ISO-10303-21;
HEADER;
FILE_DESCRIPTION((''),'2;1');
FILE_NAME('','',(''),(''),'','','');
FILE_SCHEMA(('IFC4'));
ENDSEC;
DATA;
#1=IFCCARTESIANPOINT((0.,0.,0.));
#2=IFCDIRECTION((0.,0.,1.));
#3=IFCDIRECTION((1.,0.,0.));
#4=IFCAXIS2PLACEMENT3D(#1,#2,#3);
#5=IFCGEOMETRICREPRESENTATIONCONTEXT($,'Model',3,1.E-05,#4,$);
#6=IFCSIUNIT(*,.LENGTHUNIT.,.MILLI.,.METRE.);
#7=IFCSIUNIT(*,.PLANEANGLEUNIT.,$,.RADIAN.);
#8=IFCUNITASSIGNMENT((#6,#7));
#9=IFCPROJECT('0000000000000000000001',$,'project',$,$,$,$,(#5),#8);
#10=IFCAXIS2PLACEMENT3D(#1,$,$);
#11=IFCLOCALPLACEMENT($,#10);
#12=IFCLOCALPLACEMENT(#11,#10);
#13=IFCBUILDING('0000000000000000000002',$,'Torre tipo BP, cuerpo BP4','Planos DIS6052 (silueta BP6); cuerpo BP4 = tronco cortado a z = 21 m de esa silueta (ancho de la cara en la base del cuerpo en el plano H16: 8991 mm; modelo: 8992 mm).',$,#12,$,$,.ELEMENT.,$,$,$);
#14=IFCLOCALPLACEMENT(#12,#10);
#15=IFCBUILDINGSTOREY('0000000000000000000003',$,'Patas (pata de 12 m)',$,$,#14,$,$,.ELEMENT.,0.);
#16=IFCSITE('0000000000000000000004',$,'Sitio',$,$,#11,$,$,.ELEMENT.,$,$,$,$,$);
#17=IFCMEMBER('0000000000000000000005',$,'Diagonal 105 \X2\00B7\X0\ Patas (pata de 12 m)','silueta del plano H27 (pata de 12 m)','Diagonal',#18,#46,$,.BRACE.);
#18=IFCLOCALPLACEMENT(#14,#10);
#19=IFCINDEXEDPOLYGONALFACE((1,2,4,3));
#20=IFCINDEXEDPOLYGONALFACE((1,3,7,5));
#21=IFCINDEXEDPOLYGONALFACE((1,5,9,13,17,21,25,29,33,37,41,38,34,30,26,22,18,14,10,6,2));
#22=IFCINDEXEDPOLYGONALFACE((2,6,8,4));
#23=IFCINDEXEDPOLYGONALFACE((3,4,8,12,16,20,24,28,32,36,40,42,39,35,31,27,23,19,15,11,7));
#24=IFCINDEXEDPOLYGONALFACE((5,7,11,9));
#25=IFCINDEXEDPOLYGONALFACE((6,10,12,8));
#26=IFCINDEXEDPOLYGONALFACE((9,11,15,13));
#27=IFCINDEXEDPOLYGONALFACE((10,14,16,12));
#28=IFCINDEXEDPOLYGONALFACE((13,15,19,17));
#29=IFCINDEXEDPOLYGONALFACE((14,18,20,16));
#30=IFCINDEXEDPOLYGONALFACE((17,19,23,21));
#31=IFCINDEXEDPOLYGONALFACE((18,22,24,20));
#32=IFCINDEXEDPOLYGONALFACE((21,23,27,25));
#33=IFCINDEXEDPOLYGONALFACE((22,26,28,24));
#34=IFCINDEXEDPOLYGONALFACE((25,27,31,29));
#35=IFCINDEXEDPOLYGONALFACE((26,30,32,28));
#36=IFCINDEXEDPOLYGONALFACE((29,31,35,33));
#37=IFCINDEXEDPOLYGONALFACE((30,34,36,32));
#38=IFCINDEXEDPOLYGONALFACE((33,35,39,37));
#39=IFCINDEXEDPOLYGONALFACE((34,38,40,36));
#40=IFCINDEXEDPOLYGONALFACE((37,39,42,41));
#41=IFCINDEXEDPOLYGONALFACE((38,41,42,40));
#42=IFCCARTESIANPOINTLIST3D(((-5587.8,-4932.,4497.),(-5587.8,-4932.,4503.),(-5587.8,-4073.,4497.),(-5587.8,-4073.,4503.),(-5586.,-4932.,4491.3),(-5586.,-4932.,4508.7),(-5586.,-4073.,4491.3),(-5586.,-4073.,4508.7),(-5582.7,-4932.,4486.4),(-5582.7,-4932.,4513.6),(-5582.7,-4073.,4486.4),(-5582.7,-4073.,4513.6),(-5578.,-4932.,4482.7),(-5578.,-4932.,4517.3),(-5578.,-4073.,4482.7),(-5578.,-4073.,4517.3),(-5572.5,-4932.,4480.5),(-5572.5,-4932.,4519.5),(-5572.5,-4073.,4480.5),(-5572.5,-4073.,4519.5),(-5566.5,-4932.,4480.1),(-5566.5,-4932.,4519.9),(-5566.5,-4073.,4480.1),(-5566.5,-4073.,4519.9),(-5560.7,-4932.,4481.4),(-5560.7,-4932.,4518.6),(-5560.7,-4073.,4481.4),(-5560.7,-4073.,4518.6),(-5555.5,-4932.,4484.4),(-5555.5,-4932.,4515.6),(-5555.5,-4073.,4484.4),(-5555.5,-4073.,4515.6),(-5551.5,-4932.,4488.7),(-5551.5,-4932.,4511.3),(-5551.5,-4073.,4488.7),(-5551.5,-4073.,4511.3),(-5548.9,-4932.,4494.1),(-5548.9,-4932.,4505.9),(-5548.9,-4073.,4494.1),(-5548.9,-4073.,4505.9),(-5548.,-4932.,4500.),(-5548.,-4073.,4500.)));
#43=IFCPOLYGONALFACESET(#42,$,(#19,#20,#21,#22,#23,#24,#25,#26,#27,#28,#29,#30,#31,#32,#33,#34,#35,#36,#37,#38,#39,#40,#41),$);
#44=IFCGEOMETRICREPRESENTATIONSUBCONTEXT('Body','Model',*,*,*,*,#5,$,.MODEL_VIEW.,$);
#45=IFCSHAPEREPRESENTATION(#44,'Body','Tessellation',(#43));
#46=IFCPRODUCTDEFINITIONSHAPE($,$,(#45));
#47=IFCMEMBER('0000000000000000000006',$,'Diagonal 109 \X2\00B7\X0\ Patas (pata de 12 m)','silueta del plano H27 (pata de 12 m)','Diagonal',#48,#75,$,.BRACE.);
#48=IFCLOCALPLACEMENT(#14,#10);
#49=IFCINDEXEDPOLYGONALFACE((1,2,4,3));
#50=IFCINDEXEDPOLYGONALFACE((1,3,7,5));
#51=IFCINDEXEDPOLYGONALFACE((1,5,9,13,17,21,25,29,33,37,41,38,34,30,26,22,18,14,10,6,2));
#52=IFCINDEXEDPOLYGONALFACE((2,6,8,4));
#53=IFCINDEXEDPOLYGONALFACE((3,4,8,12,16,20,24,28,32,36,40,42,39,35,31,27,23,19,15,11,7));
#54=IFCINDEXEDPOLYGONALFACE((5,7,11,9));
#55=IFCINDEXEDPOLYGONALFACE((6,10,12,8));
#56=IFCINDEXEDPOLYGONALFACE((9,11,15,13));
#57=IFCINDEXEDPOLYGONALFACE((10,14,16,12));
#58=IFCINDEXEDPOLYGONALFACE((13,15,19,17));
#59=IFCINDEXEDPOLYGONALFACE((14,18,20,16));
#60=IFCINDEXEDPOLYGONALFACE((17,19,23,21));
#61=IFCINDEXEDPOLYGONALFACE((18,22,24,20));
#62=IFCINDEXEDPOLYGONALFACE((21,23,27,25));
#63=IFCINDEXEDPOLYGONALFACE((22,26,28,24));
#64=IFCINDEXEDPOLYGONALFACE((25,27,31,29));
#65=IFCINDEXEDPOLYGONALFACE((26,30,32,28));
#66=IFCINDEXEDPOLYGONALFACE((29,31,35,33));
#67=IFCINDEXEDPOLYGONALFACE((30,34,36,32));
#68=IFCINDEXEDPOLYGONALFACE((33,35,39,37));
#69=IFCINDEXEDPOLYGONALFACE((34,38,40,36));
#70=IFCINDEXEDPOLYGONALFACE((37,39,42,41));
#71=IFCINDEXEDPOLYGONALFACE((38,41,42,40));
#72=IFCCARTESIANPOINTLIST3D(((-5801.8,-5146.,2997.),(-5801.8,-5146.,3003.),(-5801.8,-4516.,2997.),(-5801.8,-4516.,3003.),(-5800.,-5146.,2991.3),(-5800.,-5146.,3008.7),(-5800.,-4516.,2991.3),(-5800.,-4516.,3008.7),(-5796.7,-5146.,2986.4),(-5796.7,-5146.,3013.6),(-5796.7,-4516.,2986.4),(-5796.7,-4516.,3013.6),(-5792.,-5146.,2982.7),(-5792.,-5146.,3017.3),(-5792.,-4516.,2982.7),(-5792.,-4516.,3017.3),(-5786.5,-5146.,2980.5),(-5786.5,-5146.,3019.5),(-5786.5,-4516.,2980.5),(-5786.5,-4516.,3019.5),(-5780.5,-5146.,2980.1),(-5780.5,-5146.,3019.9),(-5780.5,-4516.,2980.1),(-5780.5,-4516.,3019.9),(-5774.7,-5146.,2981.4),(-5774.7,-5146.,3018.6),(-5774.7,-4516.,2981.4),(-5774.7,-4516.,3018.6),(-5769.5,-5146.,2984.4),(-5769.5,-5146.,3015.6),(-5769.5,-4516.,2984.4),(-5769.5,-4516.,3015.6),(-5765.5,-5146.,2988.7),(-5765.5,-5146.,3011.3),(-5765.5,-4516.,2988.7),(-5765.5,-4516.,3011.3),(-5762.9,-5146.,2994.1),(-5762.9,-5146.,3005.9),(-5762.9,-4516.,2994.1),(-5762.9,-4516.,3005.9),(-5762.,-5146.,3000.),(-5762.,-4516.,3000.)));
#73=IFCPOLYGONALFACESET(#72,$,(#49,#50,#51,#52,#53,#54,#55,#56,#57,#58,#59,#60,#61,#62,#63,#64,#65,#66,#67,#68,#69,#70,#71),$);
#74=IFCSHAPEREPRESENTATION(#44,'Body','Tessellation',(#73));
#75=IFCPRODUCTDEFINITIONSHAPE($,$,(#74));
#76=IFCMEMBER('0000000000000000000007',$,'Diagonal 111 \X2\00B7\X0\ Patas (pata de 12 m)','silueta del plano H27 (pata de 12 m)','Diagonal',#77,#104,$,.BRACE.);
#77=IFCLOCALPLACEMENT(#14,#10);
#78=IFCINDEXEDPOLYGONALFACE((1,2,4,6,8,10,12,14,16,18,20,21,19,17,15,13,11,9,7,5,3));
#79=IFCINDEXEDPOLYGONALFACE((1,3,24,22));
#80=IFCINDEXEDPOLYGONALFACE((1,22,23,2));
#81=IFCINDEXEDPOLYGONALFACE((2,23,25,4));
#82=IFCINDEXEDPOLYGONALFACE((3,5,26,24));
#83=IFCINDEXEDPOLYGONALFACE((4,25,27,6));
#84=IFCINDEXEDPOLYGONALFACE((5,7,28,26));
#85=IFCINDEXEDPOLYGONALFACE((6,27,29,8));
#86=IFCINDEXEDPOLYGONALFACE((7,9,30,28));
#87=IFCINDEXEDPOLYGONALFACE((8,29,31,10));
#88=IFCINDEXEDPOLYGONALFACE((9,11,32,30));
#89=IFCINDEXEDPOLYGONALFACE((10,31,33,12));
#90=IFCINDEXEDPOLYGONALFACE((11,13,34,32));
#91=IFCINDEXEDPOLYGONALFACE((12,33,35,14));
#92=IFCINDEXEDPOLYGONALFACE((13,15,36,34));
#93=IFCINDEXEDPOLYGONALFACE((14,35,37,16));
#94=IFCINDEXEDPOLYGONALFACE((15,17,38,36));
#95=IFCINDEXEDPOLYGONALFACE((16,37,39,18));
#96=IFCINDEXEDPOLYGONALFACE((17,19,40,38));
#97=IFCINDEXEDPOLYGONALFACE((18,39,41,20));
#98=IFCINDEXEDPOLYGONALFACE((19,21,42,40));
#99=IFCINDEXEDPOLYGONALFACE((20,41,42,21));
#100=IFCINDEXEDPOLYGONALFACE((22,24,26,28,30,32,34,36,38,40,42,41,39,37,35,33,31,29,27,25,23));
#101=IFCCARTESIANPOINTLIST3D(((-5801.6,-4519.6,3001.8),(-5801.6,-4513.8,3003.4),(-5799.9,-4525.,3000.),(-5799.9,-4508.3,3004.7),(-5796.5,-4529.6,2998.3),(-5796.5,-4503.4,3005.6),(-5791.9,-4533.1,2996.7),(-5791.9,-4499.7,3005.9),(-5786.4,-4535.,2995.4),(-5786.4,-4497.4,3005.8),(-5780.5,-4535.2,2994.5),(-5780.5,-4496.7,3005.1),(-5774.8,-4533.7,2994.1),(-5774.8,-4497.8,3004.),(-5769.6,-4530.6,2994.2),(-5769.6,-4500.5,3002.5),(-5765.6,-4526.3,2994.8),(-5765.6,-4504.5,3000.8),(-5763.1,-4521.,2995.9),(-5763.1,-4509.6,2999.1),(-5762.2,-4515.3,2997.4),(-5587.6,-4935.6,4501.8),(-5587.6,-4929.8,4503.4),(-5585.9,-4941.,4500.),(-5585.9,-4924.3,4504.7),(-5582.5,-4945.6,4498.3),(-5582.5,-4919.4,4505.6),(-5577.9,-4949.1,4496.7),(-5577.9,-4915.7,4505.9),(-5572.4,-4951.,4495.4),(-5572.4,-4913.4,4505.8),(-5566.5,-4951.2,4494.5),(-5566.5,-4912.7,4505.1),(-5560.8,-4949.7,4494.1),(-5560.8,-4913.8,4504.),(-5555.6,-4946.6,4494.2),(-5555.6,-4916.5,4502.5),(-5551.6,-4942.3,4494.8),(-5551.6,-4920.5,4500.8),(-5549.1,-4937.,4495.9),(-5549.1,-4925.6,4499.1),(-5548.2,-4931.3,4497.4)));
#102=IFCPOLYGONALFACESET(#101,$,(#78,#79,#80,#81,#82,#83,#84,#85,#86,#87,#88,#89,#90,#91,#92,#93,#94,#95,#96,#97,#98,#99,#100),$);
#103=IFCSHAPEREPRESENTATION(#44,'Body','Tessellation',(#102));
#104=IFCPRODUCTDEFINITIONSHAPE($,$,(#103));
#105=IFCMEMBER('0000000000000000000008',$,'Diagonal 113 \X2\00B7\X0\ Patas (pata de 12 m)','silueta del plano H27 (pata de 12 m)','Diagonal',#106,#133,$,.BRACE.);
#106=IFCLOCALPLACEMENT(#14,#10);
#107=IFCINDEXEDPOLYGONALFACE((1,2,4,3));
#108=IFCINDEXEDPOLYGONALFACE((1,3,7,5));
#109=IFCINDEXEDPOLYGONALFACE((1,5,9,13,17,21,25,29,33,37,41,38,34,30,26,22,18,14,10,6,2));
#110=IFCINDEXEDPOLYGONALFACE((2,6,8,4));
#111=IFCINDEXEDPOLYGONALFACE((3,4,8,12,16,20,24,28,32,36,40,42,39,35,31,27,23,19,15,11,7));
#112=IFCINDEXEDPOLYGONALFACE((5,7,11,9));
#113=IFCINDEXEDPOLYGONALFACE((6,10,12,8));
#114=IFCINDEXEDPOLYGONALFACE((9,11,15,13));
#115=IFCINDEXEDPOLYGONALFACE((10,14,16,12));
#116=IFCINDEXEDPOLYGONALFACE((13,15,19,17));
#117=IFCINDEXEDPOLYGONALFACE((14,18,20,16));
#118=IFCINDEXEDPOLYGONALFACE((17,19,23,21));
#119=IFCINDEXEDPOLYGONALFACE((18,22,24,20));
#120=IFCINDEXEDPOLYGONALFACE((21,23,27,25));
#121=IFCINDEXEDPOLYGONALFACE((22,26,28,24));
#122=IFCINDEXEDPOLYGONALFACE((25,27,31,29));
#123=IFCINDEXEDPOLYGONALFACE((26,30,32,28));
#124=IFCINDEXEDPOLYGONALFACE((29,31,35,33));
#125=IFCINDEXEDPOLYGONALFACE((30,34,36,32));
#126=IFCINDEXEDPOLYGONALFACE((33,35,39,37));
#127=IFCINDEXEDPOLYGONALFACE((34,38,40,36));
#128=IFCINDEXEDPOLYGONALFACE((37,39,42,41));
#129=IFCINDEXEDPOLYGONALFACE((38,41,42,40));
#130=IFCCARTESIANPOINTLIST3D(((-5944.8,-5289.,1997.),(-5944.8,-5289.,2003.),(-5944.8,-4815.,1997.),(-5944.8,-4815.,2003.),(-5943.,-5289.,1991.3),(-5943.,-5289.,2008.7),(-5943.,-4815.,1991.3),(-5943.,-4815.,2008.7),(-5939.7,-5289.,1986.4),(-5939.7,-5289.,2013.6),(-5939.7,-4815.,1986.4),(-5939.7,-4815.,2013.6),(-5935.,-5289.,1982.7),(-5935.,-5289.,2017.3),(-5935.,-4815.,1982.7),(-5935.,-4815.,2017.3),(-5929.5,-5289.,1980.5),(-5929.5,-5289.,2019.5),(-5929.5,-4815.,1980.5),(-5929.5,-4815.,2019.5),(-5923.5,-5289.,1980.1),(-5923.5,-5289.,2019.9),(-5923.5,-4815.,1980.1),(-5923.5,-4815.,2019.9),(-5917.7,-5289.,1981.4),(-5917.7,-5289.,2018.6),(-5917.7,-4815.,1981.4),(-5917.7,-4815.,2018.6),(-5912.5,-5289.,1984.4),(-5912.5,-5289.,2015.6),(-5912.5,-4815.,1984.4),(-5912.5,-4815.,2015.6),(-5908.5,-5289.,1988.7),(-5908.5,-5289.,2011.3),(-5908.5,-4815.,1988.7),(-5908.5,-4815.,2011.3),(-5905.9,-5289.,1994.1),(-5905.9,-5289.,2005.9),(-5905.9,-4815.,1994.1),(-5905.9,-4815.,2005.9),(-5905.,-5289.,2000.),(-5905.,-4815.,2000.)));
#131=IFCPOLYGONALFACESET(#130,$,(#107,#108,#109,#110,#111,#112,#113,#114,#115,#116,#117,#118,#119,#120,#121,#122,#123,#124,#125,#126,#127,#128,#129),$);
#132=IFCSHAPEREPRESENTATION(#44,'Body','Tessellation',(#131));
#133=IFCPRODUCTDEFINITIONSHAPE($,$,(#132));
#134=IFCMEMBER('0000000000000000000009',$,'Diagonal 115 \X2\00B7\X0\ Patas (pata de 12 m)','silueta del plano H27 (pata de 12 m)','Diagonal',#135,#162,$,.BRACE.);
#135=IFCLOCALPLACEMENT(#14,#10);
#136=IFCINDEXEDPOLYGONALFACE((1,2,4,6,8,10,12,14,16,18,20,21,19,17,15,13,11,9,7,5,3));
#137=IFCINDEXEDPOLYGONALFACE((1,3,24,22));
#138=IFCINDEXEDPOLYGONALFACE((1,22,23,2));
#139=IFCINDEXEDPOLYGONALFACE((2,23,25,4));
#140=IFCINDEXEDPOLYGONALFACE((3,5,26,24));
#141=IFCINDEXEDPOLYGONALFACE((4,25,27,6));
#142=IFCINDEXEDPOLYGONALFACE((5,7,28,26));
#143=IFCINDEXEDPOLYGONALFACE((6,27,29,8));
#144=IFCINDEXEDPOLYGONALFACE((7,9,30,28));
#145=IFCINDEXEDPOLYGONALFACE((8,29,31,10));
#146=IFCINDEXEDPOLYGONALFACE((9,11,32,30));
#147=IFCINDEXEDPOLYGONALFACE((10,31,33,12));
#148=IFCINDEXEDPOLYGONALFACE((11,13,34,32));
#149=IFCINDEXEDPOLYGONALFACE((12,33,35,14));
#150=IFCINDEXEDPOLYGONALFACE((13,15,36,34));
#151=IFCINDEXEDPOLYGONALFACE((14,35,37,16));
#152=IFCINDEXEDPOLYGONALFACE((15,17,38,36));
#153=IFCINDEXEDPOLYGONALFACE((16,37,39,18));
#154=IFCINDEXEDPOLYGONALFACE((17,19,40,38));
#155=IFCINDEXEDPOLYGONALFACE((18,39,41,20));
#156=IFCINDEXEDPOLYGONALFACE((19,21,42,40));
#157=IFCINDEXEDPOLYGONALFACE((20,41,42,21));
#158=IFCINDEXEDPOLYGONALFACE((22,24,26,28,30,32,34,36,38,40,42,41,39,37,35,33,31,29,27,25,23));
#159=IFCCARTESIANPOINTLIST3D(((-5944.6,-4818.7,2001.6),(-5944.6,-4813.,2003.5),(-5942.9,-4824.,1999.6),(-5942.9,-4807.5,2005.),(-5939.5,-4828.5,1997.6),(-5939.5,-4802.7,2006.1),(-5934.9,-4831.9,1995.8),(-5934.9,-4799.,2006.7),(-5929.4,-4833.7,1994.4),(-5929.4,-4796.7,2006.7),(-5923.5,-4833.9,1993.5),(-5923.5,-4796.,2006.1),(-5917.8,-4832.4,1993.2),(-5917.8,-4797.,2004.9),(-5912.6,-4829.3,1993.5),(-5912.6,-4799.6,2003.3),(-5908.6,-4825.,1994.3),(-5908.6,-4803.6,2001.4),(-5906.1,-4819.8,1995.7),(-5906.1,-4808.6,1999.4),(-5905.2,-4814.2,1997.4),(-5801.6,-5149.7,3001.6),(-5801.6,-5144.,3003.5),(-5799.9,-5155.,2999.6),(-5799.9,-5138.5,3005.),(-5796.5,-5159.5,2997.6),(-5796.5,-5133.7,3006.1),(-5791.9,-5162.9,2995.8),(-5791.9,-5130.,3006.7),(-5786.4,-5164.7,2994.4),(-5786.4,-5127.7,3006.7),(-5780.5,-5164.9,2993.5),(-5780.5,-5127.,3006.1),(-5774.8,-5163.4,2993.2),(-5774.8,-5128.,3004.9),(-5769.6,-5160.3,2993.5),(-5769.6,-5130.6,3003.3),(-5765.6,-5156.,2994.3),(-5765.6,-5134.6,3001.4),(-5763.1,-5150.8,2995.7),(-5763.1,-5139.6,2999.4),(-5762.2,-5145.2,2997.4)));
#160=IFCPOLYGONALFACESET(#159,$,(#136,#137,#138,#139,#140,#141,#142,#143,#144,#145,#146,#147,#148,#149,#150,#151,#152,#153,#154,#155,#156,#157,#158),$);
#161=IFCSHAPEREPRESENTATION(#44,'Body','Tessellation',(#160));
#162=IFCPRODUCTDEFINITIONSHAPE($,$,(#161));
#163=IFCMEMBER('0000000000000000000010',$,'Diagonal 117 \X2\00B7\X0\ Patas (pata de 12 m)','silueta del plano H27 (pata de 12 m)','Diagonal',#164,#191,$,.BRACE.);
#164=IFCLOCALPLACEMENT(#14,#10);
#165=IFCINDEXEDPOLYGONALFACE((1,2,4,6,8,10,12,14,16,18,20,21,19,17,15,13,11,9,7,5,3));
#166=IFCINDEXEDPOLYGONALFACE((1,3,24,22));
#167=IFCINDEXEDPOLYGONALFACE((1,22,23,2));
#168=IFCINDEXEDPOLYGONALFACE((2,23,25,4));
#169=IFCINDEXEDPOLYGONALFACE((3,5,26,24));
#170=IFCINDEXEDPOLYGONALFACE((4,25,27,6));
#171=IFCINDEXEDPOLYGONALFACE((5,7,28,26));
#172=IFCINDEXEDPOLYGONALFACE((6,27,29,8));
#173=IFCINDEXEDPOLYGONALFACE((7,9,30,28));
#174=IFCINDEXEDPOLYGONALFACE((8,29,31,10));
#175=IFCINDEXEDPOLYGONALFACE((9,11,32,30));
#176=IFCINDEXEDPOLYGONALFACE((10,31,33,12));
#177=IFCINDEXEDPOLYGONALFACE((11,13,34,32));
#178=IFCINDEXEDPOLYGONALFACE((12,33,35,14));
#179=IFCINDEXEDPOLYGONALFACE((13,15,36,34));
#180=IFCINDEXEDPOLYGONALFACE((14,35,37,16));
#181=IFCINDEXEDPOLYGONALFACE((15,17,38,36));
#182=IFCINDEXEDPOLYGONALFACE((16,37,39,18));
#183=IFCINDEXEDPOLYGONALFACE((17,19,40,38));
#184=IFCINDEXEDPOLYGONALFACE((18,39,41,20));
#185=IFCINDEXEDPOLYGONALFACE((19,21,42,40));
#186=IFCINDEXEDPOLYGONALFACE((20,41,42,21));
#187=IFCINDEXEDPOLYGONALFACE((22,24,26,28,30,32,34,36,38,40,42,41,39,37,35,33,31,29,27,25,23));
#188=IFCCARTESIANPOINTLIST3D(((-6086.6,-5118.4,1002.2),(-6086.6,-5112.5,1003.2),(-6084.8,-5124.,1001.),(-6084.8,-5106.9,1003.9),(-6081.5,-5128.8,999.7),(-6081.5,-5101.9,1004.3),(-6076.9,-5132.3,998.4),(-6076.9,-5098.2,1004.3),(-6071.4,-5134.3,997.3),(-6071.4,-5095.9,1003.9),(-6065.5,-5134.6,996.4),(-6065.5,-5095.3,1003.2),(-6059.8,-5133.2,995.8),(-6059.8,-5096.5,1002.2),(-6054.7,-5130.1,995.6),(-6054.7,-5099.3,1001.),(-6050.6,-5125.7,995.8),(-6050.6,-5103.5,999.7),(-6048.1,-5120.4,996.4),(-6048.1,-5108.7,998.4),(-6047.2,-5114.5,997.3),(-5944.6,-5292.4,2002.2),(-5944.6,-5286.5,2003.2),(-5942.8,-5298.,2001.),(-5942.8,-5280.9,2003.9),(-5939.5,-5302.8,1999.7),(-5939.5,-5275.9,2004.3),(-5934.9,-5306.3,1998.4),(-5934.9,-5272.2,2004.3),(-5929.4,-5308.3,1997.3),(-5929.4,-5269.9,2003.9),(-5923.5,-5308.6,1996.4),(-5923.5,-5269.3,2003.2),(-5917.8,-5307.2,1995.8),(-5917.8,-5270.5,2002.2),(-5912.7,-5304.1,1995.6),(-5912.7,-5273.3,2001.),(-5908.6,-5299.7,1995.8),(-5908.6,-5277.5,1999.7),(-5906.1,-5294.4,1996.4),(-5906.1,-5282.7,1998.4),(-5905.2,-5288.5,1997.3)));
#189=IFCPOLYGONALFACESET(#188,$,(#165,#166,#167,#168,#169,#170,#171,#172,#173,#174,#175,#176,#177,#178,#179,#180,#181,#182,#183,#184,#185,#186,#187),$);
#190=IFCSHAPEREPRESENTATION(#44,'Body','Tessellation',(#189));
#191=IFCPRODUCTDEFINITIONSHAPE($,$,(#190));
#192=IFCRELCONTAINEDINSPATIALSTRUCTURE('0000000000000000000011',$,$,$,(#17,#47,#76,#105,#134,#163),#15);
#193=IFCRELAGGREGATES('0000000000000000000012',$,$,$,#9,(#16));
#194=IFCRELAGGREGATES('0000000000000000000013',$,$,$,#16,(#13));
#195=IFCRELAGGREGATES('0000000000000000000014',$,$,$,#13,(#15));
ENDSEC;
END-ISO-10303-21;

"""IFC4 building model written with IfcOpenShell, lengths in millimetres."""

from ifc_helpers import new_model, si_unit, frame, origin, origin_with_axes, place, context, subcontext, project, spatial, circle, extrude, element, save


model = new_model("IFC4")

# Units and contexts
model_context = context("Model", 3, precision=1e-05, world=origin_with_axes())
body_context = subcontext(model_context, "Body", "Model", "MODEL_VIEW")
ifc_project = project(units=[si_unit("LENGTHUNIT", "METRE", prefix="MILLI"), si_unit("PLANEANGLEUNIT", "RADIAN")], contexts=[model_context])

# Site, building, storey
site_placement = place(None, origin())
site = spatial("IfcSite", under=ifc_project, at=site_placement, Name="Sitio", CompositionType="ELEMENT")
building_placement = place(site_placement, origin())
building = spatial("IfcBuilding", under=site, at=building_placement, Name="Torre tipo BP, cuerpo BP4", Description="Planos DIS6052 (silueta BP6); cuerpo BP4 = tronco cortado a z = 21 m de esa silueta (ancho de la cara en la base del cuerpo en el plano H16: 8991 mm; modelo: 8992 mm).", CompositionType="ELEMENT")
storey_placement = place(building_placement, origin())
storey = spatial("IfcBuildingStorey", under=building, at=storey_placement, Name="Patas (pata de 12 m)", CompositionType="ELEMENT", Elevation=0.0)

# Members
member_1_placement = place(storey_placement, frame((-5568.0, -4932.0, 4500.0), z_axis=(0.0, 1.0, 0.0), x_axis=(1.0, 0.0, 0.0)))
element("IfcMember", 1, at=member_1_placement, inside=storey, Name="Diagonal 105 · Patas (pata de 12 m)", Description="silueta del plano H27 (pata de 12 m)", ObjectType="Diagonal", PredefinedType="BRACE", context=body_context, shape_type="SweptSolid", body=[
    extrude(circle(Radius=20.0), None, (0.0, 0.0, 1.0), 859.0),
])
member_2_placement = place(storey_placement, frame((-5782.0, -5146.0, 3000.0), z_axis=(0.0, 1.0, 0.0), x_axis=(1.0, 0.0, 0.0)))
element("IfcMember", 2, at=member_2_placement, inside=storey, Name="Diagonal 109 · Patas (pata de 12 m)", Description="silueta del plano H27 (pata de 12 m)", ObjectType="Diagonal", PredefinedType="BRACE", context=body_context, shape_type="SweptSolid", body=[
    extrude(circle(Radius=20.0), None, (0.0, 0.0, 1.0), 630.0),
])
member_3_placement = place(storey_placement, frame((-5782.0, -4516.0, 3000.0), z_axis=(0.136197, -0.264756, 0.954649), x_axis=(0.990682, 0.036398, -0.131243)))
element("IfcMember", 3, at=member_3_placement, inside=storey, Name="Diagonal 111 · Patas (pata de 12 m)", Description="silueta del plano H27 (pata de 12 m)", ObjectType="Diagonal", PredefinedType="BRACE", context=body_context, shape_type="SweptSolid", body=[
    extrude(circle(Radius=20.0), None, (0.0, 0.0, 1.0), 1571.3),
])
member_4_placement = place(storey_placement, frame((-5925.0, -5289.0, 2000.0), z_axis=(0.0, 1.0, 0.0), x_axis=(1.0, 0.0, 0.0)))
element("IfcMember", 4, at=member_4_placement, inside=storey, Name="Diagonal 113 · Patas (pata de 12 m)", Description="silueta del plano H27 (pata de 12 m)", ObjectType="Diagonal", PredefinedType="BRACE", context=body_context, shape_type="SweptSolid", body=[
    extrude(circle(Radius=20.0), None, (0.0, 0.0, 1.0), 474.0),
])
member_5_placement = place(storey_placement, frame((-5925.0, -4815.0, 2000.0), z_axis=(0.134522, -0.311377, 0.940717), x_axis=(0.990911, 0.042271, -0.127708)))
element("IfcMember", 5, at=member_5_placement, inside=storey, Name="Diagonal 115 · Patas (pata de 12 m)", Description="silueta del plano H27 (pata de 12 m)", ObjectType="Diagonal", PredefinedType="BRACE", context=body_context, shape_type="SweptSolid", body=[
    extrude(circle(Radius=20.0), None, (0.0, 0.0, 1.0), 1063.0),
])
member_6_placement = place(storey_placement, frame((-6067.0, -5115.0, 1000.0), z_axis=(0.138549, -0.169771, 0.975696), x_axis=(0.990356, 0.023751, -0.136498)))
element("IfcMember", 6, at=member_6_placement, inside=storey, Name="Diagonal 117 · Patas (pata de 12 m)", Description="silueta del plano H27 (pata de 12 m)", ObjectType="Diagonal", PredefinedType="BRACE", context=body_context, shape_type="SweptSolid", body=[
    extrude(circle(Radius=20.0), None, (0.0, 0.0, 1.0), 1024.9),
])

save(model, "model.ifc")
